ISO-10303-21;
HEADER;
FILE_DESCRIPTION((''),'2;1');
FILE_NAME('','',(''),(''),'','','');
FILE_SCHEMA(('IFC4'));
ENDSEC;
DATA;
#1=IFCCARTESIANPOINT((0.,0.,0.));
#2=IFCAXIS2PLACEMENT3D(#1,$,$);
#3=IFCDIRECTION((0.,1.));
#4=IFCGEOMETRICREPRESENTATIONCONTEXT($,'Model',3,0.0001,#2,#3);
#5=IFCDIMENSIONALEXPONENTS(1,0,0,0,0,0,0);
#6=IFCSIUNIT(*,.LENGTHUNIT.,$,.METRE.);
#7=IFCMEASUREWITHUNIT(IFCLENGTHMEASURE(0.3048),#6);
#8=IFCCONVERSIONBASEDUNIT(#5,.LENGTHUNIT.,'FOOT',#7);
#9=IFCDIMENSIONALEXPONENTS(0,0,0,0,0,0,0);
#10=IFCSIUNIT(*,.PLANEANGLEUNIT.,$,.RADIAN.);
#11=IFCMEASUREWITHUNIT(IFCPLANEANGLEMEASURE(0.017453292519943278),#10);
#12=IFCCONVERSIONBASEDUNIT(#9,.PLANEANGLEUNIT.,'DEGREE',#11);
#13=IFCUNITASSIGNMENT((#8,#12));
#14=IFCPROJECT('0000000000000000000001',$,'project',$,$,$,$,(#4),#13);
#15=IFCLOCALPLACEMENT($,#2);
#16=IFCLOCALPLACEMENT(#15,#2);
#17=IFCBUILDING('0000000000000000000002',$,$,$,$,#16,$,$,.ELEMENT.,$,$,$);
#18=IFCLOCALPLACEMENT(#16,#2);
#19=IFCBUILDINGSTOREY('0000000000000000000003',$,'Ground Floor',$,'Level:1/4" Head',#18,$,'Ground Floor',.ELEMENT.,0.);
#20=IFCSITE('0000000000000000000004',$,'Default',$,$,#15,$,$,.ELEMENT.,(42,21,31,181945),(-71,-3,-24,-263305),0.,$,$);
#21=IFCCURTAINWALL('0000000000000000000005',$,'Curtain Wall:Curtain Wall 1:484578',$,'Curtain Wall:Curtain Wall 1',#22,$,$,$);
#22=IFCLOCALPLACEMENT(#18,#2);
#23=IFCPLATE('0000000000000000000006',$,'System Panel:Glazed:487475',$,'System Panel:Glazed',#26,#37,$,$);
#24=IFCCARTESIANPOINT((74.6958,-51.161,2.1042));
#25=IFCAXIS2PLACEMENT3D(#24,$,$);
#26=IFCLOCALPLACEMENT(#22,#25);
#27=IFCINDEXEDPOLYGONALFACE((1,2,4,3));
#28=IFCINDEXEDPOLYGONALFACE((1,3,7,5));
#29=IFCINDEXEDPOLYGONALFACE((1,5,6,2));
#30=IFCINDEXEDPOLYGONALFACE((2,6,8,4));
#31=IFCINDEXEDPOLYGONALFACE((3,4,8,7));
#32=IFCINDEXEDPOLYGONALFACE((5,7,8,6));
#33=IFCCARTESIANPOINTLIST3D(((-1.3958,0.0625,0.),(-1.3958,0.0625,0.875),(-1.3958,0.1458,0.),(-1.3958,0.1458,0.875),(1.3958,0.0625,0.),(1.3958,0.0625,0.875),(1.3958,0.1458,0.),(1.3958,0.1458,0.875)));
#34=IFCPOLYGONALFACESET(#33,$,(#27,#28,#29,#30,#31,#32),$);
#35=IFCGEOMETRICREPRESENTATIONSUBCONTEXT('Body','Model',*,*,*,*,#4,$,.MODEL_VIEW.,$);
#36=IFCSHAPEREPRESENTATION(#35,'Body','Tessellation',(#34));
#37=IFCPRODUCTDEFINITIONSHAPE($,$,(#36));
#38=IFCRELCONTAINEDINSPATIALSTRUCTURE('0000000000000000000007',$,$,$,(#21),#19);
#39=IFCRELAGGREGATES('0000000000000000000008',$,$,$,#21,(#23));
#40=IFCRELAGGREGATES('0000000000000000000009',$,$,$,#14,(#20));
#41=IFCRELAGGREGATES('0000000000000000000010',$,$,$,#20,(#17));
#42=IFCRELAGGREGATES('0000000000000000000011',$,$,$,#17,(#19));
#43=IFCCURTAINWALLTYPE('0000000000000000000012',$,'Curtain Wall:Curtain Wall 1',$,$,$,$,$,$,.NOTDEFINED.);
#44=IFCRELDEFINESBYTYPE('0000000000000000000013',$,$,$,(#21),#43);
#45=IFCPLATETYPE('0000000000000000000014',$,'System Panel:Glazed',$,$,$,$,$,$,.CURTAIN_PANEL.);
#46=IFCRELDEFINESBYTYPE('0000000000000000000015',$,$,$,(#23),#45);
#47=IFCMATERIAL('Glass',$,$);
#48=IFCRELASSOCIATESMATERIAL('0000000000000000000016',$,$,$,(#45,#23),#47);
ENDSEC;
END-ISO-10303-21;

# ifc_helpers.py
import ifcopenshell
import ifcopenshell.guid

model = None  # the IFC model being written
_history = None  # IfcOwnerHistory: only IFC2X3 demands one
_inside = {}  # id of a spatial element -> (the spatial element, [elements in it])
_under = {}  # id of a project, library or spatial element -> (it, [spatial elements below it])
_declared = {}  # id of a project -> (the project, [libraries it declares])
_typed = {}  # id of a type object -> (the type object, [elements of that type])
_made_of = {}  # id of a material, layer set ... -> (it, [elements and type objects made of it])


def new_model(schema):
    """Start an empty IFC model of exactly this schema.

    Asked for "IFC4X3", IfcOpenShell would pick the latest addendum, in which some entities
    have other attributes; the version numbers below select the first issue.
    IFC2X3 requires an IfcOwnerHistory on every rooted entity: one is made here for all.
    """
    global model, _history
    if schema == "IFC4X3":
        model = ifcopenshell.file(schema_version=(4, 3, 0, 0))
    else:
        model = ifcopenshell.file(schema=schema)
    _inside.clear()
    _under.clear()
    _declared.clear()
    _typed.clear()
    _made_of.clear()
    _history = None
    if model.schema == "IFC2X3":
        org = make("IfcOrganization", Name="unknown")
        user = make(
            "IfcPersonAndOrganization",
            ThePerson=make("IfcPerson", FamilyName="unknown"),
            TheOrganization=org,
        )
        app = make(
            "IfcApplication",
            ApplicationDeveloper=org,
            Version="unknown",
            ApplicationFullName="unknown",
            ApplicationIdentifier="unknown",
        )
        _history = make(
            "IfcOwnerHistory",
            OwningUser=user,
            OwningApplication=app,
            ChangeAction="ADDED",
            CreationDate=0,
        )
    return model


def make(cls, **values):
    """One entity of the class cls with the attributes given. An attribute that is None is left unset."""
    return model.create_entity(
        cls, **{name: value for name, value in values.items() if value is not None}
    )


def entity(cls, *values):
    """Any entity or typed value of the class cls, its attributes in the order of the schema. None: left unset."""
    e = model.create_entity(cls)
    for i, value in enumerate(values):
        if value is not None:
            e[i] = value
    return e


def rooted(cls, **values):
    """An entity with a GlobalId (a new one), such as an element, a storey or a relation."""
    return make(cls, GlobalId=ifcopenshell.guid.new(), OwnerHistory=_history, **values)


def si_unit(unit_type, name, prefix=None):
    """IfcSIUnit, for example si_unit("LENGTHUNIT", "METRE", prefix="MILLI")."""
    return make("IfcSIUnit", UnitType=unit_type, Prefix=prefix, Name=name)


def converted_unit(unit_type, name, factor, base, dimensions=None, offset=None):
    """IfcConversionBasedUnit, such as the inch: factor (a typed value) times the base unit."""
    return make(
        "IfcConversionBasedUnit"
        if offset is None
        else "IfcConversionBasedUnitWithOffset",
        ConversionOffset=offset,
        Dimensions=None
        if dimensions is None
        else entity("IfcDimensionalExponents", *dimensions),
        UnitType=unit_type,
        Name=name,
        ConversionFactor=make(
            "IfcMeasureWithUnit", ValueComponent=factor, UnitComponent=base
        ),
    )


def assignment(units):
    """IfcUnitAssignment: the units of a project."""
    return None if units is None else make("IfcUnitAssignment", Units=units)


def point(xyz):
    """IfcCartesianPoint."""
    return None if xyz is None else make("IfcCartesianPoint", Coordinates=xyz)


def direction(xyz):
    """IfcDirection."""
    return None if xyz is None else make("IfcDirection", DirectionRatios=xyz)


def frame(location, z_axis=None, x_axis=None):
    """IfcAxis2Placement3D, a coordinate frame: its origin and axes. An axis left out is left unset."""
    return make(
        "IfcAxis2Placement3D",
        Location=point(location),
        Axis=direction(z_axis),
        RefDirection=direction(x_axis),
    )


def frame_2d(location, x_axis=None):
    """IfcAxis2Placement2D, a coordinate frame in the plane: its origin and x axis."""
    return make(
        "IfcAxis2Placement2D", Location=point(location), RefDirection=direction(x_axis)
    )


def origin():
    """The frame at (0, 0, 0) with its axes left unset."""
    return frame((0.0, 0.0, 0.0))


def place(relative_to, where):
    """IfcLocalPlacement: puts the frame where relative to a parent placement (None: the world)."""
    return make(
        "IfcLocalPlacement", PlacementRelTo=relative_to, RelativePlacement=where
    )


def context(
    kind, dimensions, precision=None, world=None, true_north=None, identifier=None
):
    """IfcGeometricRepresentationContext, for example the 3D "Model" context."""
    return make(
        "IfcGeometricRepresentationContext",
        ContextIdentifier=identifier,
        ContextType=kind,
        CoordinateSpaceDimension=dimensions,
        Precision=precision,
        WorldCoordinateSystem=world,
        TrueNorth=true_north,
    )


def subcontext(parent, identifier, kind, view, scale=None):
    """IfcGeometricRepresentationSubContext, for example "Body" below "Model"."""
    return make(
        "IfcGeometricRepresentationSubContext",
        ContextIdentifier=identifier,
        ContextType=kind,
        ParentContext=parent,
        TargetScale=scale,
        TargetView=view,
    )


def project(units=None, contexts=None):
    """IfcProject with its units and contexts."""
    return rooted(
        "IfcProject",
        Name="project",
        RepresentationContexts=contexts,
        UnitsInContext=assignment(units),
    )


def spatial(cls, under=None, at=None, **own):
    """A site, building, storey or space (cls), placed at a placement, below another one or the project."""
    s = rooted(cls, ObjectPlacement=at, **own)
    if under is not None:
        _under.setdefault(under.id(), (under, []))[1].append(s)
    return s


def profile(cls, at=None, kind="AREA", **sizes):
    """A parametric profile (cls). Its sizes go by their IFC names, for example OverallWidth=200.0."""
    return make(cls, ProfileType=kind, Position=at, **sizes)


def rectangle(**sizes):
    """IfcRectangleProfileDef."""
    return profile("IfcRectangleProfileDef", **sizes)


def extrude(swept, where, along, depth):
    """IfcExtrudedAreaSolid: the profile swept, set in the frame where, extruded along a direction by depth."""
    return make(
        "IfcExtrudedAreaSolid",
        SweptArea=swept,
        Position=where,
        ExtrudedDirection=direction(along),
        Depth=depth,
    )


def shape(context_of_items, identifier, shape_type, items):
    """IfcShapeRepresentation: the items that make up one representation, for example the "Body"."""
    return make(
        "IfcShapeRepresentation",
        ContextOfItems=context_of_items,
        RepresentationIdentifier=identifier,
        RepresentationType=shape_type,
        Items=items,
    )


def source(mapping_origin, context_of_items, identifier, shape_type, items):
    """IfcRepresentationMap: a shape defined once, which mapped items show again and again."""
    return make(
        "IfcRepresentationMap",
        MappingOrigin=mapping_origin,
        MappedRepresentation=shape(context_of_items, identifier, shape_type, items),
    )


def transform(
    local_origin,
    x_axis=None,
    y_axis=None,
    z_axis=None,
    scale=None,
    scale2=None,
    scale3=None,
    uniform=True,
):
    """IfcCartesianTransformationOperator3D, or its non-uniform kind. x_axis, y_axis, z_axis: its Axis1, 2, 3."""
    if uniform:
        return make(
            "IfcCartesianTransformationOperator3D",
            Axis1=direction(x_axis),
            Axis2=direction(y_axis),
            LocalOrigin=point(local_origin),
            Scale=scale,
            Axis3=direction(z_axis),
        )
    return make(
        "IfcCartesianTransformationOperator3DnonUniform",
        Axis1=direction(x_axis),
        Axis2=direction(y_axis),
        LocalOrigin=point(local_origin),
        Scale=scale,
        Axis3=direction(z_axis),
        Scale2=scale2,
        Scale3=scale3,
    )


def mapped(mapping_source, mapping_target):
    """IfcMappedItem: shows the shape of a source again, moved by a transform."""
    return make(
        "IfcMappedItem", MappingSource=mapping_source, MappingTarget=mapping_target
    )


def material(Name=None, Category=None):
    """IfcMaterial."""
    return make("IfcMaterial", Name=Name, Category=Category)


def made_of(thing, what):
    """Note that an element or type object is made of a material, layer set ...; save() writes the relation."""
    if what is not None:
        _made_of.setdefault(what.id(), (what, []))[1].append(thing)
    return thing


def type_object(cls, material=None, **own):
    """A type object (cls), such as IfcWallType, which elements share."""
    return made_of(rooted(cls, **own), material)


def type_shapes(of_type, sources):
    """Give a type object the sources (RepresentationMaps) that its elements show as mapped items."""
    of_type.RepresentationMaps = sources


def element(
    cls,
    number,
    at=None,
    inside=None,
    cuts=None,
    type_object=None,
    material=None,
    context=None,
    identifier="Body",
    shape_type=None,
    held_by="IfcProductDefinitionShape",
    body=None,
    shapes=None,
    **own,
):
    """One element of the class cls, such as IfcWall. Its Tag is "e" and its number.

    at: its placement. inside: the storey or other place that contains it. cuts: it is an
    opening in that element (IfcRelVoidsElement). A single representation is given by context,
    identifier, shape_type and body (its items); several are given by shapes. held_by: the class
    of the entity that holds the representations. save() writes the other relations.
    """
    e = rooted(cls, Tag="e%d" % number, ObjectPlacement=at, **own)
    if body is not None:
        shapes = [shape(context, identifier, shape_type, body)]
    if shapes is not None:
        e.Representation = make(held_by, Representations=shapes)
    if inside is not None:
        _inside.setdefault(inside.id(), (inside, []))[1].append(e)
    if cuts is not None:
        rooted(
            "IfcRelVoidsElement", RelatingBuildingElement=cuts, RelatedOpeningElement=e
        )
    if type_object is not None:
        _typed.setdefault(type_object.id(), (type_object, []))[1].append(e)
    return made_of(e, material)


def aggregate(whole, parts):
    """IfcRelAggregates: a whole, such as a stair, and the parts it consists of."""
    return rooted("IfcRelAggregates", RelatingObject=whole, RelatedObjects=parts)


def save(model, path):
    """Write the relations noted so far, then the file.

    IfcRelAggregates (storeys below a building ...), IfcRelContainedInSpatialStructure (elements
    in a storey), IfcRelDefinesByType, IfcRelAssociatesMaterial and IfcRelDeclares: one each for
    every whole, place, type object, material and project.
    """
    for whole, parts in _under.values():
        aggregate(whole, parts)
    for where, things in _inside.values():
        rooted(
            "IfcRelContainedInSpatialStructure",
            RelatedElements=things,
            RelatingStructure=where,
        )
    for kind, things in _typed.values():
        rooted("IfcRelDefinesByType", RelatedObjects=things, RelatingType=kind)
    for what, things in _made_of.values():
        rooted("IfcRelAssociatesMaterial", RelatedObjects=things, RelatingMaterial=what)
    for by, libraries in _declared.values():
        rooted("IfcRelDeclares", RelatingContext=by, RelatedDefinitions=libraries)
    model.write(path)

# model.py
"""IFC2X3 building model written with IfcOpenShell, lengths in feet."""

from ifc_helpers import new_model, entity, si_unit, converted_unit, direction, frame, frame_2d, origin, place, context, subcontext, project, spatial, rectangle, extrude, source, transform, mapped, material, type_object, type_shapes, element, aggregate, save


model = new_model("IFC2X3")

# Units and contexts
model_context = context("Model", 3, precision=0.0001, world=origin(), true_north=direction((0.0, 1.0)))
body_context = subcontext(model_context, "Body", "Model", "MODEL_VIEW")
ifc_project = project(units=[converted_unit("LENGTHUNIT", "FOOT", entity("IfcLengthMeasure", 0.3048), si_unit("LENGTHUNIT", "METRE"), dimensions=[1, 0, 0, 0, 0, 0, 0]), converted_unit("PLANEANGLEUNIT", "DEGREE", entity("IfcPlaneAngleMeasure", 0.017453292519943278), si_unit("PLANEANGLEUNIT", "RADIAN"), dimensions=[0, 0, 0, 0, 0, 0, 0])], contexts=[model_context])

# Site, building, storey
site_placement = place(None, origin())
site = spatial("IfcSite", under=ifc_project, at=site_placement, Name="Default", CompositionType="ELEMENT", RefLatitude=(42, 21, 31, 181945), RefLongitude=(-71, -3, -24, -263305), RefElevation=0.0)
building_placement = place(site_placement, origin())
building = spatial("IfcBuilding", under=site, at=building_placement, CompositionType="ELEMENT")
storey_placement = place(building_placement, origin())
storey = spatial("IfcBuildingStorey", under=building, at=storey_placement, Name="Ground Floor", ObjectType="Level:1/4\" Head", LongName="Ground Floor", CompositionType="ELEMENT", Elevation=0.0)

# Curtain wall, plate
curtain_wall_type = type_object("IfcCurtainWallType", Name="Curtain Wall:Curtain Wall 1", PredefinedType="NOTDEFINED")
curtain_wall_placement = place(storey_placement, origin())
curtain_wall = element("IfcCurtainWall", 1, at=curtain_wall_placement, inside=storey, type_object=curtain_wall_type, Name="Curtain Wall:Curtain Wall 1:484578", ObjectType="Curtain Wall:Curtain Wall 1")
ifc_material_1 = material(Name="Glass")
plate_type_1 = type_object("IfcPlateType", Name="System Panel:Glazed", PredefinedType="CURTAIN_PANEL", material=ifc_material_1)
shared_shape_1 = source(origin(), body_context, "Body", "SweptSolid", [
    extrude(rectangle(XDim=0.0833, YDim=2.7917, at=frame_2d((0.0, 0.0), x_axis=(1.0, 0.0))), frame((0.0, 0.1042, 0.0), z_axis=(0.0, 0.0, 1.0), x_axis=(0.0, 1.0, 0.0)), (0.0, 0.0, 1.0), 0.875),
])
type_shapes(plate_type_1, [shared_shape_1])
plate_1_placement = place(curtain_wall_placement, frame((74.6958, -51.161, 2.1042)))
plate_1 = element("IfcPlate", 2, at=plate_1_placement, type_object=plate_type_1, material=ifc_material_1, Name="System Panel:Glazed:487475", ObjectType="System Panel:Glazed", context=body_context, shape_type="MappedRepresentation", body=[
    mapped(shared_shape_1, transform((0.0, 0.0, 0.0), scale=1.0)),
])
aggregate(curtain_wall, [plate_1])

save(model, "model.ifc")
